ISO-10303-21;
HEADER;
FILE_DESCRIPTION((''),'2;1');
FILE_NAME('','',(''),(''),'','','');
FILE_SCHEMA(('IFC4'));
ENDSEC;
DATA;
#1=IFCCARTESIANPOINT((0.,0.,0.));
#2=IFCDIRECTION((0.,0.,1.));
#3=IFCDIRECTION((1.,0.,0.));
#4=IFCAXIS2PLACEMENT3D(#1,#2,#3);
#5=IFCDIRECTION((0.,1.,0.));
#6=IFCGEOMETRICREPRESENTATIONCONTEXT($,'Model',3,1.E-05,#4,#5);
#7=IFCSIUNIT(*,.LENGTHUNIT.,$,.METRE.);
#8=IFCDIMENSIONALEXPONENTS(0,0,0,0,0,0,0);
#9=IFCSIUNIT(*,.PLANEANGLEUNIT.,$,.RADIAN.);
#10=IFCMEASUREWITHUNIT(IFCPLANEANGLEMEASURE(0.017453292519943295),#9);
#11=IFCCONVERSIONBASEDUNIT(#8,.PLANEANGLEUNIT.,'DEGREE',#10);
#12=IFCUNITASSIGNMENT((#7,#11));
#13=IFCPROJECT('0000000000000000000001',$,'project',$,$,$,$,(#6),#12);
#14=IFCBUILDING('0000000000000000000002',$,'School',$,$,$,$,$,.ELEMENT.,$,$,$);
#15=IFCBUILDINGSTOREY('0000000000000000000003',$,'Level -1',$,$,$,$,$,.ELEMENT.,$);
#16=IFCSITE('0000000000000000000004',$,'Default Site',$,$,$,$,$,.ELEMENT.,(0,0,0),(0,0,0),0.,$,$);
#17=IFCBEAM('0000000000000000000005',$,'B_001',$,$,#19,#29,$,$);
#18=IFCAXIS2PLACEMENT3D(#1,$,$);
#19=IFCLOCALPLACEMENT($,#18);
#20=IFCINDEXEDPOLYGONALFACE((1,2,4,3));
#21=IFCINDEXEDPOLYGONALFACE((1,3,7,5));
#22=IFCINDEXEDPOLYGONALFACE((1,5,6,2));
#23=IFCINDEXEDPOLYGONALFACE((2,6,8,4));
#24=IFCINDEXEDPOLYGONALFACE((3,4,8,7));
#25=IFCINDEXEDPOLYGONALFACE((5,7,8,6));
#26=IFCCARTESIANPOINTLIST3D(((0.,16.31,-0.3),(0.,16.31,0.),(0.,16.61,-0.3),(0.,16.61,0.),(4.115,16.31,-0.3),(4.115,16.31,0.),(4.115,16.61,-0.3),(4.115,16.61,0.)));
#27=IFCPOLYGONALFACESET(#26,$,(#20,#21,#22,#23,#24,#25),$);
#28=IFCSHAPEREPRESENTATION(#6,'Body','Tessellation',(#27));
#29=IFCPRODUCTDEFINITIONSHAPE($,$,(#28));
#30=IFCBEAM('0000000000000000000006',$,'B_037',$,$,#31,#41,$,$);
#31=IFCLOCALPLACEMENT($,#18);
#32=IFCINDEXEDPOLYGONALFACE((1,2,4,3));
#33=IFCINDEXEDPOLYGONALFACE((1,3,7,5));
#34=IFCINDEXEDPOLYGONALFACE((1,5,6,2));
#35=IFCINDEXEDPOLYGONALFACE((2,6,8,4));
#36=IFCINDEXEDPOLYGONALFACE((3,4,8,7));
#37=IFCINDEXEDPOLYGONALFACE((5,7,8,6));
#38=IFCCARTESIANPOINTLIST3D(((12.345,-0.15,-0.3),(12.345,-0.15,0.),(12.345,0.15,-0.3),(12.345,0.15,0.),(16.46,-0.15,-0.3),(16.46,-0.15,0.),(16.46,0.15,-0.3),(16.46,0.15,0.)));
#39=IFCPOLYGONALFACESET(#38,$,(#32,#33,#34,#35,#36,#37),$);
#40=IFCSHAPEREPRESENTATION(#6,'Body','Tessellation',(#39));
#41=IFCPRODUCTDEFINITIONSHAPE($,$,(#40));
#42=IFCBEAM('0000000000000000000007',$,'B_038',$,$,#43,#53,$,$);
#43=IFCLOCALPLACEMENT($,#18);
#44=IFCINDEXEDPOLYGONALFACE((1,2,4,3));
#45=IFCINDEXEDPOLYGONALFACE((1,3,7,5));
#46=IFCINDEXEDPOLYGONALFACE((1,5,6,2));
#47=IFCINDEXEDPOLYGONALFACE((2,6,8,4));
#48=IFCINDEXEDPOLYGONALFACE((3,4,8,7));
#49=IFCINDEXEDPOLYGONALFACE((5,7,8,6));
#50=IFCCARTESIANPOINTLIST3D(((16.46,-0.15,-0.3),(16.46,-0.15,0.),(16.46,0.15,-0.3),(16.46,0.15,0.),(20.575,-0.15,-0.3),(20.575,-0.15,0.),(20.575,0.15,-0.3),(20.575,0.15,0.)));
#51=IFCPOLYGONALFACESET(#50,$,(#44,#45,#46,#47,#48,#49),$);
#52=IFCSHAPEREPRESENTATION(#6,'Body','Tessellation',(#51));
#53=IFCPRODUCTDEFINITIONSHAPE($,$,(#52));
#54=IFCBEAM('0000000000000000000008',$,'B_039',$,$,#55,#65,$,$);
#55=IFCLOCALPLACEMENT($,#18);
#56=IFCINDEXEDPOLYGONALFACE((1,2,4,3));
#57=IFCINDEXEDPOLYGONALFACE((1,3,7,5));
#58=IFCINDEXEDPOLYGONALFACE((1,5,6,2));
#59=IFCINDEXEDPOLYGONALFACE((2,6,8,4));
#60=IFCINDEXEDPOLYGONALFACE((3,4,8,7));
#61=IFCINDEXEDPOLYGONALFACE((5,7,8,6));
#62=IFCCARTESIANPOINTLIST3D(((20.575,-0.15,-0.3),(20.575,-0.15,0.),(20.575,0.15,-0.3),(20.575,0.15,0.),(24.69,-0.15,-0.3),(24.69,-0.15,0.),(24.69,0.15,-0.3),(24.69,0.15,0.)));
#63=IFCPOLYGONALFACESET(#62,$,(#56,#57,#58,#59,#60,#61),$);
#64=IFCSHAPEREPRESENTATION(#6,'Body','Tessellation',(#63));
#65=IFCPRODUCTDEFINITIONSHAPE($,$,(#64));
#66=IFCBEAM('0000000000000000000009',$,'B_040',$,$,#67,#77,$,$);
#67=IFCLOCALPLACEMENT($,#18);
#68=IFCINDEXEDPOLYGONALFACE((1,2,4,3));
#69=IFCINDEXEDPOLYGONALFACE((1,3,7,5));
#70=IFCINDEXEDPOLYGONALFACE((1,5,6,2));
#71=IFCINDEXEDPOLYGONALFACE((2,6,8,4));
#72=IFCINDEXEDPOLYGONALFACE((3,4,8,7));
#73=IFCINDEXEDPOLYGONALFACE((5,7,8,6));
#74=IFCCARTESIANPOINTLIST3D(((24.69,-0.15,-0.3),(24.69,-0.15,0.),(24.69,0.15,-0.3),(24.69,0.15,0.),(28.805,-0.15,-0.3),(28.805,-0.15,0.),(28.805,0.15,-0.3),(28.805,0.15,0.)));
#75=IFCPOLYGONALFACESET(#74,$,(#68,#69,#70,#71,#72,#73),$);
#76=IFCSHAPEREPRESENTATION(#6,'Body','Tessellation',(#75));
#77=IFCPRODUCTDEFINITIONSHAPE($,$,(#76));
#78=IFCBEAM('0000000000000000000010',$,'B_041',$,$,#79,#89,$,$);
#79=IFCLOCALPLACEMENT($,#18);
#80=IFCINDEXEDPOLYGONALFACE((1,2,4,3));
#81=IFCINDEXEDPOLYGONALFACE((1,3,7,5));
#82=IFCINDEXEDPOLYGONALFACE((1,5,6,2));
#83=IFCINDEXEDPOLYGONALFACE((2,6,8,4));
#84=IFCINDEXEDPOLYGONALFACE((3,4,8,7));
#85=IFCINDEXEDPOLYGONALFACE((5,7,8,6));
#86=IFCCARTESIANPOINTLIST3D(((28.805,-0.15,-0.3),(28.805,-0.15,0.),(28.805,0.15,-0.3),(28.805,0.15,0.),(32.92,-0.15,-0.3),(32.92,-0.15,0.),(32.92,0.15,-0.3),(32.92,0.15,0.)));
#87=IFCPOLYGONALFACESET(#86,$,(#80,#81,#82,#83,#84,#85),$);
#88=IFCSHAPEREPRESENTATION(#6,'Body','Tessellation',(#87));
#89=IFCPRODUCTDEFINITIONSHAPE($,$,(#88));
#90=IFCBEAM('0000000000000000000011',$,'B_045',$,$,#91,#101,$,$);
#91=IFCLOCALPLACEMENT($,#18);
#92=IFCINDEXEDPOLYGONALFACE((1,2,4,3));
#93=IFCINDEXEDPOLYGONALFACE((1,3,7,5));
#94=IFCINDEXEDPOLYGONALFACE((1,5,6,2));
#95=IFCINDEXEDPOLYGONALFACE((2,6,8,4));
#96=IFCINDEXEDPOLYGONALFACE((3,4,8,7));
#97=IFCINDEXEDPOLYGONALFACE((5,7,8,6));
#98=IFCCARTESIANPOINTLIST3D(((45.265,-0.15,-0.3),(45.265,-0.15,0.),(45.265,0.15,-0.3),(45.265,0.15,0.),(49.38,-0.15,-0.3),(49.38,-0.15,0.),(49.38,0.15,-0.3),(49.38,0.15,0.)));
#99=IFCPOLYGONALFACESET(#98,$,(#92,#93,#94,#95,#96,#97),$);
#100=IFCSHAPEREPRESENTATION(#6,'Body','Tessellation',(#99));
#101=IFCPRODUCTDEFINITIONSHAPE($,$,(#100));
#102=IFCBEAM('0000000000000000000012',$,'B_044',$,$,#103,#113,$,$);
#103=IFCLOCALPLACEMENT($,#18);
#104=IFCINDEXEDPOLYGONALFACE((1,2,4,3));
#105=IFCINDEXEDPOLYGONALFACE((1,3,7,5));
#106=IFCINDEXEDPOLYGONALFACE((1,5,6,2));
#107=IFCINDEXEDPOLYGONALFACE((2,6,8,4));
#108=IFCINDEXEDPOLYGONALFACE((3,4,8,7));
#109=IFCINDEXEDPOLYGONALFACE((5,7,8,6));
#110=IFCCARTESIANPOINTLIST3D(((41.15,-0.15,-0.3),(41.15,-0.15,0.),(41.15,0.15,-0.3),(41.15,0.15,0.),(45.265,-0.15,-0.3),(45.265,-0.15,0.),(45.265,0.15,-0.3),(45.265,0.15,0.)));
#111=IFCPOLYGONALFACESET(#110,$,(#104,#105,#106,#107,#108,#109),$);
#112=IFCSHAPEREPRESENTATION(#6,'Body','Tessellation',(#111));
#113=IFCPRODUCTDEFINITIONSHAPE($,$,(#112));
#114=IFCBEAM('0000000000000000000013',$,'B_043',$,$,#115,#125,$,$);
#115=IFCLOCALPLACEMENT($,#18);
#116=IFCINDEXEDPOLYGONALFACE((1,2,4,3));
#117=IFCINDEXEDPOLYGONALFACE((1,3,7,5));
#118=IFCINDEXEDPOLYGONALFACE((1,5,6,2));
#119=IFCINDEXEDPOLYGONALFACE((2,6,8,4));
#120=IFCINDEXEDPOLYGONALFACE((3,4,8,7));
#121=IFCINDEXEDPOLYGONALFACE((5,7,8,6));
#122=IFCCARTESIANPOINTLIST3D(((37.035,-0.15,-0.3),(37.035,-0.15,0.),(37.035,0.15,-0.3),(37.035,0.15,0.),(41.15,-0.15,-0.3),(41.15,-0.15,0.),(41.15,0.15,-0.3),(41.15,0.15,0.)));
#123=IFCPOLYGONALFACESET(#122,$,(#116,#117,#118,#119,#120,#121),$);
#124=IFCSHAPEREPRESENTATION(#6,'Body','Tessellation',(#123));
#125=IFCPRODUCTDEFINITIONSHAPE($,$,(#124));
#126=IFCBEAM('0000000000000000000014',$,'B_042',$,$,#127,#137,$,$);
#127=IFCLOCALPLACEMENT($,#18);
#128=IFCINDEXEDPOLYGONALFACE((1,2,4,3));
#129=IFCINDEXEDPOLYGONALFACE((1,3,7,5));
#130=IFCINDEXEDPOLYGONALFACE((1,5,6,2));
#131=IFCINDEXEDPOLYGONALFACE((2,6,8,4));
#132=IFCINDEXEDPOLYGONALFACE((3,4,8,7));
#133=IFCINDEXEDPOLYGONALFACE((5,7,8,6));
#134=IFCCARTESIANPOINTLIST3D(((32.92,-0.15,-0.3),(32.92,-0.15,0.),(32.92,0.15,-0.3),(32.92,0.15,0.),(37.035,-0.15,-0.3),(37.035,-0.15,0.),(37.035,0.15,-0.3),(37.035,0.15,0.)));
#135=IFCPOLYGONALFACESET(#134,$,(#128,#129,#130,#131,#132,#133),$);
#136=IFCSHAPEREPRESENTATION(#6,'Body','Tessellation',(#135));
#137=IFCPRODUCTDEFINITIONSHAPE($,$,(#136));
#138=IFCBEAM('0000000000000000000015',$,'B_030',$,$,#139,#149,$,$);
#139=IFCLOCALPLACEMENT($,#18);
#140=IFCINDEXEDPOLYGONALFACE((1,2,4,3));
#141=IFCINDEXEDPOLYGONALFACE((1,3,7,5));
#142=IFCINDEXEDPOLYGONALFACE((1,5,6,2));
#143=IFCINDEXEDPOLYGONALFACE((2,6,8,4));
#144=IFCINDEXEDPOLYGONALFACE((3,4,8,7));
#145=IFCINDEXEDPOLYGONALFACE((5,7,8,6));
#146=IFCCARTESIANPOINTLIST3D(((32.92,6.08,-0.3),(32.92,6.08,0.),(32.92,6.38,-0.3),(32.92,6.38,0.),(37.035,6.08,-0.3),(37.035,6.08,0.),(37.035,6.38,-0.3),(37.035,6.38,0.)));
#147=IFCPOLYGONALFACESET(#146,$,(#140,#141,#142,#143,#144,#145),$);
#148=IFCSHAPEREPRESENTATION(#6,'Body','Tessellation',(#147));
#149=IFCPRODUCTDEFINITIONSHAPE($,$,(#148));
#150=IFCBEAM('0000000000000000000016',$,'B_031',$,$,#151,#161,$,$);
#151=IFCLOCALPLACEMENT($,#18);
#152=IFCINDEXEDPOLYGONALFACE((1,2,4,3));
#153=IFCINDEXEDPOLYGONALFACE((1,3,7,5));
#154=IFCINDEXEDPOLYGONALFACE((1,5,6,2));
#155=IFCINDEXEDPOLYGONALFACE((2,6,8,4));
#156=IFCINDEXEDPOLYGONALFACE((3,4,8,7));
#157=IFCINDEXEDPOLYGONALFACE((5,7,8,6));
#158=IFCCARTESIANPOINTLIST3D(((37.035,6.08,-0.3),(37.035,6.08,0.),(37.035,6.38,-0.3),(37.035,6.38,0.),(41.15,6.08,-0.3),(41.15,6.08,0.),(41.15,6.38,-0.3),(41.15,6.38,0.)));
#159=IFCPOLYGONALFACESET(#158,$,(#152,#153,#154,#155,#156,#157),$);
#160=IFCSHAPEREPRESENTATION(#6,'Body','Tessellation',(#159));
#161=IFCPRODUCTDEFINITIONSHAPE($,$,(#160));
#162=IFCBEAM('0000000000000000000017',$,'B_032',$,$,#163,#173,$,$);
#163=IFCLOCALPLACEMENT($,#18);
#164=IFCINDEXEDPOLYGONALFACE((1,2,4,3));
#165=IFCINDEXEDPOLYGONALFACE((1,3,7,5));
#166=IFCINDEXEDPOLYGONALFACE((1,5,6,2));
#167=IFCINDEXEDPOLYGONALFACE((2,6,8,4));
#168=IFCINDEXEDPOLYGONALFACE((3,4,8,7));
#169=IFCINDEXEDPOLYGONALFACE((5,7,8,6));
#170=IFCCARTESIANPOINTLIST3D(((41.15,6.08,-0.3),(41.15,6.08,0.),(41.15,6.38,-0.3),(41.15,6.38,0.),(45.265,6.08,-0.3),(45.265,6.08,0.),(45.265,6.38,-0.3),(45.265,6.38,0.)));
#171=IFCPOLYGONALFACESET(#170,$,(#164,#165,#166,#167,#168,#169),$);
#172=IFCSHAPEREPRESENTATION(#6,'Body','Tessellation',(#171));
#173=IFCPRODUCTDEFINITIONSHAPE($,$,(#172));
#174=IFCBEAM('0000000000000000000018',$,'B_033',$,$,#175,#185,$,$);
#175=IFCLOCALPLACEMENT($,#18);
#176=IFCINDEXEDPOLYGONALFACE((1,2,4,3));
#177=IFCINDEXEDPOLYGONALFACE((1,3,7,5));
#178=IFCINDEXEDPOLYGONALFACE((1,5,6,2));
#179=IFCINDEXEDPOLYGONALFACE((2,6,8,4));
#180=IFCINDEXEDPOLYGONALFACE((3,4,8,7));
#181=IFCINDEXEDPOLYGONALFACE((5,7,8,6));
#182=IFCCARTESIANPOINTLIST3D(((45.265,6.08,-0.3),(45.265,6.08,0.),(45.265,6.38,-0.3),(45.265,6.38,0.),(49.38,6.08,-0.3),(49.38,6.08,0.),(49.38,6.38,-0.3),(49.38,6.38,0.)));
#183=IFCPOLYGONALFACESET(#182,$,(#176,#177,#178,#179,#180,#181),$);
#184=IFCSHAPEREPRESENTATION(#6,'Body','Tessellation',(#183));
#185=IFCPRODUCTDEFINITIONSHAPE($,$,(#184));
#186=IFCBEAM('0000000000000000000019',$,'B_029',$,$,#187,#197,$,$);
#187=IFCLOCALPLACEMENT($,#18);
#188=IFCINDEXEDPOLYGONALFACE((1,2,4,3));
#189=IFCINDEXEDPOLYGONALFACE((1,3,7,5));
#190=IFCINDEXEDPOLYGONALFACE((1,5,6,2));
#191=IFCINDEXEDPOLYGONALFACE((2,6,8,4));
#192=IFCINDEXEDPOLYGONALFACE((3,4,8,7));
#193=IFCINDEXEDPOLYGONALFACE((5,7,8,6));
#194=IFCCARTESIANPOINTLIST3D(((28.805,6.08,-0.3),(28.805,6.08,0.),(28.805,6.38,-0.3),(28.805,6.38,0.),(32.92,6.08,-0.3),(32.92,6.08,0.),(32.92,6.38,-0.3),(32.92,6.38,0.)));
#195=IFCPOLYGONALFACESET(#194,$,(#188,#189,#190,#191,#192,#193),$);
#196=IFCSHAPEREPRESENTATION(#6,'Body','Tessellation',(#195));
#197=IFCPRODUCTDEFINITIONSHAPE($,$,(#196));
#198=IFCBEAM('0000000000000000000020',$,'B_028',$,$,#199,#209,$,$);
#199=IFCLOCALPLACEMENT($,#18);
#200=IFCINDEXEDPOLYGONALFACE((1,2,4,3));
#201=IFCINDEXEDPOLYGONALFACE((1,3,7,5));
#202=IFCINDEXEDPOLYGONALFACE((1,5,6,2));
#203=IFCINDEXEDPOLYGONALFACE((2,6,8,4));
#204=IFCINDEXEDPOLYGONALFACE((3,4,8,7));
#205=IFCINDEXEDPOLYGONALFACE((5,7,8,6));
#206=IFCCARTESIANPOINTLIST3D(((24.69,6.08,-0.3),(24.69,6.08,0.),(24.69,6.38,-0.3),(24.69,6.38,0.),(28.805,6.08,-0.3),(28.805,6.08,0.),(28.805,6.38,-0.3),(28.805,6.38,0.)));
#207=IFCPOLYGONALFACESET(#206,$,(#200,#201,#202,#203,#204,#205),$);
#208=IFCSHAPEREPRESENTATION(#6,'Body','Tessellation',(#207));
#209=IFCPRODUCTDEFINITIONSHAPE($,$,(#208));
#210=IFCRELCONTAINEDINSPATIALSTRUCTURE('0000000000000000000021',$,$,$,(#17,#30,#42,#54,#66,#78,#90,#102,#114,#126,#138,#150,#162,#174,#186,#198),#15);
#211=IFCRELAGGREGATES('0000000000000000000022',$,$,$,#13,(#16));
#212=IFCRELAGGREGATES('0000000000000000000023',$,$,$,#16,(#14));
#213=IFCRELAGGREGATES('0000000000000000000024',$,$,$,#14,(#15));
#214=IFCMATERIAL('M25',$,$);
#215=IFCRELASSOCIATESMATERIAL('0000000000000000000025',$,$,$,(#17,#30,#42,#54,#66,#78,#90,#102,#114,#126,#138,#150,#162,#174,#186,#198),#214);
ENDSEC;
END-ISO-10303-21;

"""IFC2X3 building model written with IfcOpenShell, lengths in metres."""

from ifc_helpers import new_model, entity, si_unit, converted_unit, direction, frame, frame_2d, origin_with_axes, place, context, project, spatial, rectangle, extrude, material, element, save


model = new_model("IFC2X3")

# Units and contexts
model_context = context("Model", 3, precision=1e-05, world=origin_with_axes(), true_north=direction((0.0, 1.0, 0.0)))
ifc_project = project(units=[si_unit("LENGTHUNIT", "METRE"), converted_unit("PLANEANGLEUNIT", "DEGREE", entity("IfcPlaneAngleMeasure", 0.017453292519943295), si_unit("PLANEANGLEUNIT", "RADIAN"), dimensions=[0, 0, 0, 0, 0, 0, 0])], contexts=[model_context])

# Site, building, storey
site = spatial("IfcSite", under=ifc_project, Name="Default Site", CompositionType="ELEMENT", RefLatitude=(0, 0, 0), RefLongitude=(0, 0, 0), RefElevation=0.0)
building = spatial("IfcBuilding", under=site, Name="School", CompositionType="ELEMENT")
storey = spatial("IfcBuildingStorey", under=building, Name="Level -1", CompositionType="ELEMENT")

# Shared definitions
ifc_material = material(Name="M25")
placement = place(None, origin_with_axes())

# Beams
element("IfcBeam", 1, at=placement, inside=storey, material=ifc_material, Name="B_001", context=model_context, shape_type="SweptSolid", body=[
    extrude(rectangle(XDim=0.3, YDim=0.3, at=frame_2d((0.0, 0.0), x_axis=(0.0, 1.0, 0.0))), frame((0.0, 16.46, -0.15), z_axis=(1.0, 0.0, 0.0), x_axis=(0.0, 0.0, -1.0)), (0.0, 0.0, 1.0), 4.115),
])
element("IfcBeam", 2, at=placement, inside=storey, material=ifc_material, Name="B_037", context=model_context, shape_type="SweptSolid", body=[
    extrude(rectangle(XDim=0.3, YDim=0.3, at=frame_2d((0.0, 0.0), x_axis=(0.0, 1.0, 0.0))), frame((12.345, 0.0, -0.15), z_axis=(1.0, 0.0, 0.0), x_axis=(0.0, 0.0, -1.0)), (0.0, 0.0, 1.0), 4.115),
])
element("IfcBeam", 3, at=placement, inside=storey, material=ifc_material, Name="B_038", context=model_context, shape_type="SweptSolid", body=[
    extrude(rectangle(XDim=0.3, YDim=0.3, at=frame_2d((0.0, 0.0), x_axis=(0.0, 1.0, 0.0))), frame((16.46, 0.0, -0.15), z_axis=(1.0, 0.0, 0.0), x_axis=(0.0, 0.0, -1.0)), (0.0, 0.0, 1.0), 4.115),
])
element("IfcBeam", 4, at=placement, inside=storey, material=ifc_material, Name="B_039", context=model_context, shape_type="SweptSolid", body=[
    extrude(rectangle(XDim=0.3, YDim=0.3, at=frame_2d((0.0, 0.0), x_axis=(0.0, 1.0, 0.0))), frame((20.575, 0.0, -0.15), z_axis=(1.0, 0.0, 0.0), x_axis=(0.0, 0.0, -1.0)), (0.0, 0.0, 1.0), 4.115),
])
element("IfcBeam", 5, at=placement, inside=storey, material=ifc_material, Name="B_040", context=model_context, shape_type="SweptSolid", body=[
    extrude(rectangle(XDim=0.3, YDim=0.3, at=frame_2d((0.0, 0.0), x_axis=(0.0, 1.0, 0.0))), frame((24.69, 0.0, -0.15), z_axis=(1.0, 0.0, 0.0), x_axis=(0.0, 0.0, -1.0)), (0.0, 0.0, 1.0), 4.115),
])
element("IfcBeam", 6, at=placement, inside=storey, material=ifc_material, Name="B_041", context=model_context, shape_type="SweptSolid", body=[
    extrude(rectangle(XDim=0.3, YDim=0.3, at=frame_2d((0.0, 0.0), x_axis=(0.0, 1.0, 0.0))), frame((28.805, 0.0, -0.15), z_axis=(1.0, 0.0, 0.0), x_axis=(0.0, 0.0, -1.0)), (0.0, 0.0, 1.0), 4.115),
])
element("IfcBeam", 7, at=placement, inside=storey, material=ifc_material, Name="B_045", context=model_context, shape_type="SweptSolid", body=[
    extrude(rectangle(XDim=0.3, YDim=0.3, at=frame_2d((0.0, 0.0), x_axis=(0.0, 1.0, 0.0))), frame((45.265, 0.0, -0.15), z_axis=(1.0, 0.0, 0.0), x_axis=(0.0, 0.0, -1.0)), (0.0, 0.0, 1.0), 4.115),
])
element("IfcBeam", 8, at=placement, inside=storey, material=ifc_material, Name="B_044", context=model_context, shape_type="SweptSolid", body=[
    extrude(rectangle(XDim=0.3, YDim=0.3, at=frame_2d((0.0, 0.0), x_axis=(0.0, 1.0, 0.0))), frame((41.15, 0.0, -0.15), z_axis=(1.0, 0.0, 0.0), x_axis=(0.0, 0.0, -1.0)), (0.0, 0.0, 1.0), 4.115),
])
element("IfcBeam", 9, at=placement, inside=storey, material=ifc_material, Name="B_043", context=model_context, shape_type="SweptSolid", body=[
    extrude(rectangle(XDim=0.3, YDim=0.3, at=frame_2d((0.0, 0.0), x_axis=(0.0, 1.0, 0.0))), frame((37.035, 0.0, -0.15), z_axis=(1.0, 0.0, 0.0), x_axis=(0.0, 0.0, -1.0)), (0.0, 0.0, 1.0), 4.115),
])
element("IfcBeam", 10, at=placement, inside=storey, material=ifc_material, Name="B_042", context=model_context, shape_type="SweptSolid", body=[
    extrude(rectangle(XDim=0.3, YDim=0.3, at=frame_2d((0.0, 0.0), x_axis=(0.0, 1.0, 0.0))), frame((32.92, 0.0, -0.15), z_axis=(1.0, 0.0, 0.0), x_axis=(0.0, 0.0, -1.0)), (0.0, 0.0, 1.0), 4.115),
])
element("IfcBeam", 11, at=placement, inside=storey, material=ifc_material, Name="B_030", context=model_context, shape_type="SweptSolid", body=[
    extrude(rectangle(XDim=0.3, YDim=0.3, at=frame_2d((0.0, 0.0), x_axis=(0.0, 1.0, 0.0))), frame((32.92, 6.23, -0.15), z_axis=(1.0, 0.0, 0.0), x_axis=(0.0, 0.0, -1.0)), (0.0, 0.0, 1.0), 4.115),
])
element("IfcBeam", 12, at=placement, inside=storey, material=ifc_material, Name="B_031", context=model_context, shape_type="SweptSolid", body=[
    extrude(rectangle(XDim=0.3, YDim=0.3, at=frame_2d((0.0, 0.0), x_axis=(0.0, 1.0, 0.0))), frame((37.035, 6.23, -0.15), z_axis=(1.0, 0.0, 0.0), x_axis=(0.0, 0.0, -1.0)), (0.0, 0.0, 1.0), 4.115),
])
element("IfcBeam", 13, at=placement, inside=storey, material=ifc_material, Name="B_032", context=model_context, shape_type="SweptSolid", body=[
    extrude(rectangle(XDim=0.3, YDim=0.3, at=frame_2d((0.0, 0.0), x_axis=(0.0, 1.0, 0.0))), frame((41.15, 6.23, -0.15), z_axis=(1.0, 0.0, 0.0), x_axis=(0.0, 0.0, -1.0)), (0.0, 0.0, 1.0), 4.115),
])
element("IfcBeam", 14, at=placement, inside=storey, material=ifc_material, Name="B_033", context=model_context, shape_type="SweptSolid", body=[
    extrude(rectangle(XDim=0.3, YDim=0.3, at=frame_2d((0.0, 0.0), x_axis=(0.0, 1.0, 0.0))), frame((45.265, 6.23, -0.15), z_axis=(1.0, 0.0, 0.0), x_axis=(0.0, 0.0, -1.0)), (0.0, 0.0, 1.0), 4.115),
])
element("IfcBeam", 15, at=placement, inside=storey, material=ifc_material, Name="B_029", context=model_context, shape_type="SweptSolid", body=[
    extrude(rectangle(XDim=0.3, YDim=0.3, at=frame_2d((0.0, 0.0), x_axis=(0.0, 1.0, 0.0))), frame((28.805, 6.23, -0.15), z_axis=(1.0, 0.0, 0.0), x_axis=(0.0, 0.0, -1.0)), (0.0, 0.0, 1.0), 4.115),
])
element("IfcBeam", 16, at=placement, inside=storey, material=ifc_material, Name="B_028", context=model_context, shape_type="SweptSolid", body=[
    extrude(rectangle(XDim=0.3, YDim=0.3, at=frame_2d((0.0, 0.0), x_axis=(0.0, 1.0, 0.0))), frame((24.69, 6.23, -0.15), z_axis=(1.0, 0.0, 0.0), x_axis=(0.0, 0.0, -1.0)), (0.0, 0.0, 1.0), 4.115),
])

save(model, "model.ifc")
